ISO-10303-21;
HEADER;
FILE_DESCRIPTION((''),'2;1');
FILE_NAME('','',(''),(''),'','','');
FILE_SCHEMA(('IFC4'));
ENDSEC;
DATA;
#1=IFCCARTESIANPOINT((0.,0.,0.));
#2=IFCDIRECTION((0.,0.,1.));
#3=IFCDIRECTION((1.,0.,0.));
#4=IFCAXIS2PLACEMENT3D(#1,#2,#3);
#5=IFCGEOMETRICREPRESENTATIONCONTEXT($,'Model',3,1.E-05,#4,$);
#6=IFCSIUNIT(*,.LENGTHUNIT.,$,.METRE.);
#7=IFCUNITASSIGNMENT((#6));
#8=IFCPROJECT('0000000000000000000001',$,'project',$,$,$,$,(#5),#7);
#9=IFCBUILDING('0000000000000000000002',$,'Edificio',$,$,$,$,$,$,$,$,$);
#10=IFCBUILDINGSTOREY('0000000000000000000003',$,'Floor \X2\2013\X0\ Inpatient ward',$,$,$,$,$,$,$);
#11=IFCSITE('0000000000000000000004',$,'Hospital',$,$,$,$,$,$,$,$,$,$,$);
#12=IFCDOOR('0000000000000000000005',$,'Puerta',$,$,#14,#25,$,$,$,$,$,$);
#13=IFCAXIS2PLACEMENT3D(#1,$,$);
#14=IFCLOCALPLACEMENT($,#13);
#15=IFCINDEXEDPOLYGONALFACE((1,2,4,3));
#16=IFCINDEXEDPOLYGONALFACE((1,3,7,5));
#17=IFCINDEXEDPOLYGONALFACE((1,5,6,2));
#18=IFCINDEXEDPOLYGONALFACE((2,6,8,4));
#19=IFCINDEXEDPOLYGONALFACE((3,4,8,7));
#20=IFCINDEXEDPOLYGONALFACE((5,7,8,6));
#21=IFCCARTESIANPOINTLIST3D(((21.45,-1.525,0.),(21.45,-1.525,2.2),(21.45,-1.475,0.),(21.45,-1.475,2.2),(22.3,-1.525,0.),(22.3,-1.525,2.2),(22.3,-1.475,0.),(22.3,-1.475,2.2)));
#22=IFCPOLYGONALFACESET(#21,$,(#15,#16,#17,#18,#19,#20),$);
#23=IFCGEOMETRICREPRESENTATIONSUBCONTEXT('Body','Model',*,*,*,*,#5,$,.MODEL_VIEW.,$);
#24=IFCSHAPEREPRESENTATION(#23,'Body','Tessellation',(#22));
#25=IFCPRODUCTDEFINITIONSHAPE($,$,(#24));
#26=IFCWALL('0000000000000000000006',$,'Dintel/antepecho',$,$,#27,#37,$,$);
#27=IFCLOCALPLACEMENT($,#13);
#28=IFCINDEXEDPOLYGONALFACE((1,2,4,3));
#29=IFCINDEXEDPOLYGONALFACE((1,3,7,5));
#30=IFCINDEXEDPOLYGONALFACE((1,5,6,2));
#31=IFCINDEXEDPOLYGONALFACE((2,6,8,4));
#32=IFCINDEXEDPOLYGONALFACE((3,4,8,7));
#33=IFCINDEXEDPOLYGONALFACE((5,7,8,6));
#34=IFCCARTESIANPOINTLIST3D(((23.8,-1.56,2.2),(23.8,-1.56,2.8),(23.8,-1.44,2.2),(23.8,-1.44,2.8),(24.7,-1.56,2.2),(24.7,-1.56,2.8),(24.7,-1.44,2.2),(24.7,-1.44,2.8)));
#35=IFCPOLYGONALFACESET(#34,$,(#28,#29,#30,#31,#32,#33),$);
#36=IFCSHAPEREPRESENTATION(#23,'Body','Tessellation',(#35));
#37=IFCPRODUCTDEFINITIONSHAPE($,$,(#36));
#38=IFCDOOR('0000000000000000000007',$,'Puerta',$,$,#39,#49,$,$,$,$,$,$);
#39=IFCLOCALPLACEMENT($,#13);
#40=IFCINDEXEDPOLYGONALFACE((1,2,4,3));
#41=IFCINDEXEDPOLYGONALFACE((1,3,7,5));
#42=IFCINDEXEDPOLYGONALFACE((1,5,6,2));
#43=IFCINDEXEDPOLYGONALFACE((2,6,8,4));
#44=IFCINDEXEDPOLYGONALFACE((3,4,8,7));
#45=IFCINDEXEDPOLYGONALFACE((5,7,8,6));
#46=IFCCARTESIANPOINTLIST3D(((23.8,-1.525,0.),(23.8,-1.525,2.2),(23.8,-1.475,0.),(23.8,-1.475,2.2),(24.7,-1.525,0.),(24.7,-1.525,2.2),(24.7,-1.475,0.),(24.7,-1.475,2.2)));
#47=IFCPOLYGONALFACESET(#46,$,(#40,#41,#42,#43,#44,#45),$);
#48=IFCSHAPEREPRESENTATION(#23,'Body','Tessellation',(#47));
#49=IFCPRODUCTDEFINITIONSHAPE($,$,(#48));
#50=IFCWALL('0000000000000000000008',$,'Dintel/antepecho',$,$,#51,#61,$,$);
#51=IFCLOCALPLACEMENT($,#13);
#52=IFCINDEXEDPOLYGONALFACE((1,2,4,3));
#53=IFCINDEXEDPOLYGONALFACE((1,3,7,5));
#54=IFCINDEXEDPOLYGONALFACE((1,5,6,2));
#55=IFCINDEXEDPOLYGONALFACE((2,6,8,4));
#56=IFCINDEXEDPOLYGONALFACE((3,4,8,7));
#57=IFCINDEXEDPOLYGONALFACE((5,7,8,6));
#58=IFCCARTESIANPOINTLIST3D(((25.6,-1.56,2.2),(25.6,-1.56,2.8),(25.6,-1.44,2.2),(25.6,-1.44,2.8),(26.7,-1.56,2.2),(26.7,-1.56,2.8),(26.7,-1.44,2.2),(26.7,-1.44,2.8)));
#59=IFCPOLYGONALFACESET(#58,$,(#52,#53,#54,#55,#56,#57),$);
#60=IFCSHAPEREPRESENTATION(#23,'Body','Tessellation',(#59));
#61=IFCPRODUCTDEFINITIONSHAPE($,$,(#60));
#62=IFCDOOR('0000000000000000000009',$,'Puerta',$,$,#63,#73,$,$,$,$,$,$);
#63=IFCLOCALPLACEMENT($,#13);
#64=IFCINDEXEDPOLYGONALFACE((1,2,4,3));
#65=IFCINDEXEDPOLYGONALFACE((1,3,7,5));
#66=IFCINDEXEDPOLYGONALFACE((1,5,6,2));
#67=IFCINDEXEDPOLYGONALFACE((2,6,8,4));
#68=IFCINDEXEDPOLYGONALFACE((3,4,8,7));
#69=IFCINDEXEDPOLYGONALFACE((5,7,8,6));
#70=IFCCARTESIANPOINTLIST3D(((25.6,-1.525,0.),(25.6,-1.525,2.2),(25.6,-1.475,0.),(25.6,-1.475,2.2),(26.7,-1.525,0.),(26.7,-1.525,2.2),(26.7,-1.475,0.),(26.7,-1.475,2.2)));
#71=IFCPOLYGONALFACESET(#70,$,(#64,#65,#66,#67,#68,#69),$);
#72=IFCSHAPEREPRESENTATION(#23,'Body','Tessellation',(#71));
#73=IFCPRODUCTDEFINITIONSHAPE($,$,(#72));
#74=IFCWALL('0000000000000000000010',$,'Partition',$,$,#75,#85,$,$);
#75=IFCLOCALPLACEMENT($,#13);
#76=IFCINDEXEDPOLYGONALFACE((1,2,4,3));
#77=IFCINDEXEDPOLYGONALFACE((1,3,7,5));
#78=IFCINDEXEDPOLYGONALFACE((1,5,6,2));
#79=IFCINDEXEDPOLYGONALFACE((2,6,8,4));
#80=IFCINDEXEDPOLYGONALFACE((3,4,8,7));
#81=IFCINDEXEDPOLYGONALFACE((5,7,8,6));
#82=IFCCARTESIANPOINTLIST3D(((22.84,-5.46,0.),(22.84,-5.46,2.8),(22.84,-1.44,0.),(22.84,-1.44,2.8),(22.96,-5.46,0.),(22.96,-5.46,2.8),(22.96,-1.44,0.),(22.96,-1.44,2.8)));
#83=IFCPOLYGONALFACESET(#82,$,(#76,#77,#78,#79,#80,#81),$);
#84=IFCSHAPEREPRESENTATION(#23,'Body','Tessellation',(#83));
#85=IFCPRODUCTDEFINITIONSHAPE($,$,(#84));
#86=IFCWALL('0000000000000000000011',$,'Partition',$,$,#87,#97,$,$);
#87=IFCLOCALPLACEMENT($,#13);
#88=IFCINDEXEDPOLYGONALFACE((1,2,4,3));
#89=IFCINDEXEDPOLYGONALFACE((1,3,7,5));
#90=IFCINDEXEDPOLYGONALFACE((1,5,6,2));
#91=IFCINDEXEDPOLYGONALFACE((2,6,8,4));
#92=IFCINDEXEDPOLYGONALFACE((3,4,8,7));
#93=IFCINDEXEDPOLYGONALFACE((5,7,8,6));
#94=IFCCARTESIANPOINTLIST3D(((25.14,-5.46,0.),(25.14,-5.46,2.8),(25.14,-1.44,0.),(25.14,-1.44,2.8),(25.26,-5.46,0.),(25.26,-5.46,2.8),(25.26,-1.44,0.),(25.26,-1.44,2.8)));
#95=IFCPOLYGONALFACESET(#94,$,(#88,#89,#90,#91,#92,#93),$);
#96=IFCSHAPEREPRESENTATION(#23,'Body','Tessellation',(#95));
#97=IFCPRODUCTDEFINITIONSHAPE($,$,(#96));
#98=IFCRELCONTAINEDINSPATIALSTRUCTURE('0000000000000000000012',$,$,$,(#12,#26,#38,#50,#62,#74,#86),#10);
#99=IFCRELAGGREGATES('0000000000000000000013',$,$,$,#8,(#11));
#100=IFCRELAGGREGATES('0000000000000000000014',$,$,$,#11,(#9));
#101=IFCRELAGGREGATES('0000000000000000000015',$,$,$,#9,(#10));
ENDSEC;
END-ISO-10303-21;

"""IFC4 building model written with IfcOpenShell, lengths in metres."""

from ifc_helpers import new_model, si_unit, frame, origin_with_axes, context, subcontext, project, spatial, line, indexed_curve, outline, extrude, element, save


model = new_model("IFC4")

# Units and contexts
model_context = context("Model", 3, precision=1e-05, world=origin_with_axes())
body_context = subcontext(model_context, "Body", "Model", "MODEL_VIEW")
ifc_project = project(units=[si_unit("LENGTHUNIT", "METRE")], contexts=[model_context])

# Site, building, storey
site = spatial("IfcSite", under=ifc_project, Name="Hospital")
building = spatial("IfcBuilding", under=site, Name="Edificio")
storey = spatial("IfcBuildingStorey", under=building, Name="Floor – Inpatient ward")

# Door
element("IfcDoor", 1, inside=storey, Name="Puerta", context=body_context, shape_type="SweptSolid", body=[
    extrude(outline(indexed_curve([(0.0, 0.0), (0.85, 0.0), (0.85, 0.05), (0.0, 0.05)], segments=[line(1, 2, 3, 4, 1)])), frame((21.45, -1.525, 0.0), z_axis=(0.0, 0.0, 1.0), x_axis=(1.0, 0.0, 0.0)), (0.0, 0.0, 1.0), 2.2),
])

# Wall
element("IfcWall", 2, inside=storey, Name="Dintel/antepecho", context=body_context, shape_type="SweptSolid", body=[
    extrude(outline(indexed_curve([(0.0, 0.0), (0.9, 0.0), (0.9, 0.12), (0.0, 0.12)], segments=[line(1, 2, 3, 4, 1)])), frame((23.8, -1.56, 2.2), z_axis=(0.0, 0.0, 1.0), x_axis=(1.0, 0.0, 0.0)), (0.0, 0.0, 1.0), 0.6),
])

# Door
element("IfcDoor", 3, inside=storey, Name="Puerta", context=body_context, shape_type="SweptSolid", body=[
    extrude(outline(indexed_curve([(0.0, 0.0), (0.9, 0.0), (0.9, 0.05), (0.0, 0.05)], segments=[line(1, 2, 3, 4, 1)])), frame((23.8, -1.525, 0.0), z_axis=(0.0, 0.0, 1.0), x_axis=(1.0, 0.0, 0.0)), (0.0, 0.0, 1.0), 2.2),
])

# Wall
element("IfcWall", 4, inside=storey, Name="Dintel/antepecho", context=body_context, shape_type="SweptSolid", body=[
    extrude(outline(indexed_curve([(0.0, 0.0), (1.1, 0.0), (1.1, 0.12), (0.0, 0.12)], segments=[line(1, 2, 3, 4, 1)])), frame((25.6, -1.56, 2.2), z_axis=(0.0, 0.0, 1.0), x_axis=(1.0, 0.0, 0.0)), (0.0, 0.0, 1.0), 0.6),
])

# Door
element("IfcDoor", 5, inside=storey, Name="Puerta", context=body_context, shape_type="SweptSolid", body=[
    extrude(outline(indexed_curve([(0.0, 0.0), (1.1, 0.0), (1.1, 0.05), (0.0, 0.05)], segments=[line(1, 2, 3, 4, 1)])), frame((25.6, -1.525, 0.0), z_axis=(0.0, 0.0, 1.0), x_axis=(1.0, 0.0, 0.0)), (0.0, 0.0, 1.0), 2.2),
])

# Walls
element("IfcWall", 6, inside=storey, Name="Partition", context=body_context, shape_type="SweptSolid", body=[
    extrude(outline(indexed_curve([(0.0, 0.0), (0.12, 0.0), (0.12, 4.02), (0.0, 4.02)], segments=[line(1, 2, 3, 4, 1)])), frame((22.84, -5.46, 0.0), z_axis=(0.0, 0.0, 1.0), x_axis=(1.0, 0.0, 0.0)), (0.0, 0.0, 1.0), 2.8),
])
element("IfcWall", 7, inside=storey, Name="Partition", context=body_context, shape_type="SweptSolid", body=[
    extrude(outline(indexed_curve([(0.0, 0.0), (0.12, 0.0), (0.12, 4.02), (0.0, 4.02)], segments=[line(1, 2, 3, 4, 1)])), frame((25.14, -5.46, 0.0), z_axis=(0.0, 0.0, 1.0), x_axis=(1.0, 0.0, 0.0)), (0.0, 0.0, 1.0), 2.8),
])

save(model, "model.ifc")
